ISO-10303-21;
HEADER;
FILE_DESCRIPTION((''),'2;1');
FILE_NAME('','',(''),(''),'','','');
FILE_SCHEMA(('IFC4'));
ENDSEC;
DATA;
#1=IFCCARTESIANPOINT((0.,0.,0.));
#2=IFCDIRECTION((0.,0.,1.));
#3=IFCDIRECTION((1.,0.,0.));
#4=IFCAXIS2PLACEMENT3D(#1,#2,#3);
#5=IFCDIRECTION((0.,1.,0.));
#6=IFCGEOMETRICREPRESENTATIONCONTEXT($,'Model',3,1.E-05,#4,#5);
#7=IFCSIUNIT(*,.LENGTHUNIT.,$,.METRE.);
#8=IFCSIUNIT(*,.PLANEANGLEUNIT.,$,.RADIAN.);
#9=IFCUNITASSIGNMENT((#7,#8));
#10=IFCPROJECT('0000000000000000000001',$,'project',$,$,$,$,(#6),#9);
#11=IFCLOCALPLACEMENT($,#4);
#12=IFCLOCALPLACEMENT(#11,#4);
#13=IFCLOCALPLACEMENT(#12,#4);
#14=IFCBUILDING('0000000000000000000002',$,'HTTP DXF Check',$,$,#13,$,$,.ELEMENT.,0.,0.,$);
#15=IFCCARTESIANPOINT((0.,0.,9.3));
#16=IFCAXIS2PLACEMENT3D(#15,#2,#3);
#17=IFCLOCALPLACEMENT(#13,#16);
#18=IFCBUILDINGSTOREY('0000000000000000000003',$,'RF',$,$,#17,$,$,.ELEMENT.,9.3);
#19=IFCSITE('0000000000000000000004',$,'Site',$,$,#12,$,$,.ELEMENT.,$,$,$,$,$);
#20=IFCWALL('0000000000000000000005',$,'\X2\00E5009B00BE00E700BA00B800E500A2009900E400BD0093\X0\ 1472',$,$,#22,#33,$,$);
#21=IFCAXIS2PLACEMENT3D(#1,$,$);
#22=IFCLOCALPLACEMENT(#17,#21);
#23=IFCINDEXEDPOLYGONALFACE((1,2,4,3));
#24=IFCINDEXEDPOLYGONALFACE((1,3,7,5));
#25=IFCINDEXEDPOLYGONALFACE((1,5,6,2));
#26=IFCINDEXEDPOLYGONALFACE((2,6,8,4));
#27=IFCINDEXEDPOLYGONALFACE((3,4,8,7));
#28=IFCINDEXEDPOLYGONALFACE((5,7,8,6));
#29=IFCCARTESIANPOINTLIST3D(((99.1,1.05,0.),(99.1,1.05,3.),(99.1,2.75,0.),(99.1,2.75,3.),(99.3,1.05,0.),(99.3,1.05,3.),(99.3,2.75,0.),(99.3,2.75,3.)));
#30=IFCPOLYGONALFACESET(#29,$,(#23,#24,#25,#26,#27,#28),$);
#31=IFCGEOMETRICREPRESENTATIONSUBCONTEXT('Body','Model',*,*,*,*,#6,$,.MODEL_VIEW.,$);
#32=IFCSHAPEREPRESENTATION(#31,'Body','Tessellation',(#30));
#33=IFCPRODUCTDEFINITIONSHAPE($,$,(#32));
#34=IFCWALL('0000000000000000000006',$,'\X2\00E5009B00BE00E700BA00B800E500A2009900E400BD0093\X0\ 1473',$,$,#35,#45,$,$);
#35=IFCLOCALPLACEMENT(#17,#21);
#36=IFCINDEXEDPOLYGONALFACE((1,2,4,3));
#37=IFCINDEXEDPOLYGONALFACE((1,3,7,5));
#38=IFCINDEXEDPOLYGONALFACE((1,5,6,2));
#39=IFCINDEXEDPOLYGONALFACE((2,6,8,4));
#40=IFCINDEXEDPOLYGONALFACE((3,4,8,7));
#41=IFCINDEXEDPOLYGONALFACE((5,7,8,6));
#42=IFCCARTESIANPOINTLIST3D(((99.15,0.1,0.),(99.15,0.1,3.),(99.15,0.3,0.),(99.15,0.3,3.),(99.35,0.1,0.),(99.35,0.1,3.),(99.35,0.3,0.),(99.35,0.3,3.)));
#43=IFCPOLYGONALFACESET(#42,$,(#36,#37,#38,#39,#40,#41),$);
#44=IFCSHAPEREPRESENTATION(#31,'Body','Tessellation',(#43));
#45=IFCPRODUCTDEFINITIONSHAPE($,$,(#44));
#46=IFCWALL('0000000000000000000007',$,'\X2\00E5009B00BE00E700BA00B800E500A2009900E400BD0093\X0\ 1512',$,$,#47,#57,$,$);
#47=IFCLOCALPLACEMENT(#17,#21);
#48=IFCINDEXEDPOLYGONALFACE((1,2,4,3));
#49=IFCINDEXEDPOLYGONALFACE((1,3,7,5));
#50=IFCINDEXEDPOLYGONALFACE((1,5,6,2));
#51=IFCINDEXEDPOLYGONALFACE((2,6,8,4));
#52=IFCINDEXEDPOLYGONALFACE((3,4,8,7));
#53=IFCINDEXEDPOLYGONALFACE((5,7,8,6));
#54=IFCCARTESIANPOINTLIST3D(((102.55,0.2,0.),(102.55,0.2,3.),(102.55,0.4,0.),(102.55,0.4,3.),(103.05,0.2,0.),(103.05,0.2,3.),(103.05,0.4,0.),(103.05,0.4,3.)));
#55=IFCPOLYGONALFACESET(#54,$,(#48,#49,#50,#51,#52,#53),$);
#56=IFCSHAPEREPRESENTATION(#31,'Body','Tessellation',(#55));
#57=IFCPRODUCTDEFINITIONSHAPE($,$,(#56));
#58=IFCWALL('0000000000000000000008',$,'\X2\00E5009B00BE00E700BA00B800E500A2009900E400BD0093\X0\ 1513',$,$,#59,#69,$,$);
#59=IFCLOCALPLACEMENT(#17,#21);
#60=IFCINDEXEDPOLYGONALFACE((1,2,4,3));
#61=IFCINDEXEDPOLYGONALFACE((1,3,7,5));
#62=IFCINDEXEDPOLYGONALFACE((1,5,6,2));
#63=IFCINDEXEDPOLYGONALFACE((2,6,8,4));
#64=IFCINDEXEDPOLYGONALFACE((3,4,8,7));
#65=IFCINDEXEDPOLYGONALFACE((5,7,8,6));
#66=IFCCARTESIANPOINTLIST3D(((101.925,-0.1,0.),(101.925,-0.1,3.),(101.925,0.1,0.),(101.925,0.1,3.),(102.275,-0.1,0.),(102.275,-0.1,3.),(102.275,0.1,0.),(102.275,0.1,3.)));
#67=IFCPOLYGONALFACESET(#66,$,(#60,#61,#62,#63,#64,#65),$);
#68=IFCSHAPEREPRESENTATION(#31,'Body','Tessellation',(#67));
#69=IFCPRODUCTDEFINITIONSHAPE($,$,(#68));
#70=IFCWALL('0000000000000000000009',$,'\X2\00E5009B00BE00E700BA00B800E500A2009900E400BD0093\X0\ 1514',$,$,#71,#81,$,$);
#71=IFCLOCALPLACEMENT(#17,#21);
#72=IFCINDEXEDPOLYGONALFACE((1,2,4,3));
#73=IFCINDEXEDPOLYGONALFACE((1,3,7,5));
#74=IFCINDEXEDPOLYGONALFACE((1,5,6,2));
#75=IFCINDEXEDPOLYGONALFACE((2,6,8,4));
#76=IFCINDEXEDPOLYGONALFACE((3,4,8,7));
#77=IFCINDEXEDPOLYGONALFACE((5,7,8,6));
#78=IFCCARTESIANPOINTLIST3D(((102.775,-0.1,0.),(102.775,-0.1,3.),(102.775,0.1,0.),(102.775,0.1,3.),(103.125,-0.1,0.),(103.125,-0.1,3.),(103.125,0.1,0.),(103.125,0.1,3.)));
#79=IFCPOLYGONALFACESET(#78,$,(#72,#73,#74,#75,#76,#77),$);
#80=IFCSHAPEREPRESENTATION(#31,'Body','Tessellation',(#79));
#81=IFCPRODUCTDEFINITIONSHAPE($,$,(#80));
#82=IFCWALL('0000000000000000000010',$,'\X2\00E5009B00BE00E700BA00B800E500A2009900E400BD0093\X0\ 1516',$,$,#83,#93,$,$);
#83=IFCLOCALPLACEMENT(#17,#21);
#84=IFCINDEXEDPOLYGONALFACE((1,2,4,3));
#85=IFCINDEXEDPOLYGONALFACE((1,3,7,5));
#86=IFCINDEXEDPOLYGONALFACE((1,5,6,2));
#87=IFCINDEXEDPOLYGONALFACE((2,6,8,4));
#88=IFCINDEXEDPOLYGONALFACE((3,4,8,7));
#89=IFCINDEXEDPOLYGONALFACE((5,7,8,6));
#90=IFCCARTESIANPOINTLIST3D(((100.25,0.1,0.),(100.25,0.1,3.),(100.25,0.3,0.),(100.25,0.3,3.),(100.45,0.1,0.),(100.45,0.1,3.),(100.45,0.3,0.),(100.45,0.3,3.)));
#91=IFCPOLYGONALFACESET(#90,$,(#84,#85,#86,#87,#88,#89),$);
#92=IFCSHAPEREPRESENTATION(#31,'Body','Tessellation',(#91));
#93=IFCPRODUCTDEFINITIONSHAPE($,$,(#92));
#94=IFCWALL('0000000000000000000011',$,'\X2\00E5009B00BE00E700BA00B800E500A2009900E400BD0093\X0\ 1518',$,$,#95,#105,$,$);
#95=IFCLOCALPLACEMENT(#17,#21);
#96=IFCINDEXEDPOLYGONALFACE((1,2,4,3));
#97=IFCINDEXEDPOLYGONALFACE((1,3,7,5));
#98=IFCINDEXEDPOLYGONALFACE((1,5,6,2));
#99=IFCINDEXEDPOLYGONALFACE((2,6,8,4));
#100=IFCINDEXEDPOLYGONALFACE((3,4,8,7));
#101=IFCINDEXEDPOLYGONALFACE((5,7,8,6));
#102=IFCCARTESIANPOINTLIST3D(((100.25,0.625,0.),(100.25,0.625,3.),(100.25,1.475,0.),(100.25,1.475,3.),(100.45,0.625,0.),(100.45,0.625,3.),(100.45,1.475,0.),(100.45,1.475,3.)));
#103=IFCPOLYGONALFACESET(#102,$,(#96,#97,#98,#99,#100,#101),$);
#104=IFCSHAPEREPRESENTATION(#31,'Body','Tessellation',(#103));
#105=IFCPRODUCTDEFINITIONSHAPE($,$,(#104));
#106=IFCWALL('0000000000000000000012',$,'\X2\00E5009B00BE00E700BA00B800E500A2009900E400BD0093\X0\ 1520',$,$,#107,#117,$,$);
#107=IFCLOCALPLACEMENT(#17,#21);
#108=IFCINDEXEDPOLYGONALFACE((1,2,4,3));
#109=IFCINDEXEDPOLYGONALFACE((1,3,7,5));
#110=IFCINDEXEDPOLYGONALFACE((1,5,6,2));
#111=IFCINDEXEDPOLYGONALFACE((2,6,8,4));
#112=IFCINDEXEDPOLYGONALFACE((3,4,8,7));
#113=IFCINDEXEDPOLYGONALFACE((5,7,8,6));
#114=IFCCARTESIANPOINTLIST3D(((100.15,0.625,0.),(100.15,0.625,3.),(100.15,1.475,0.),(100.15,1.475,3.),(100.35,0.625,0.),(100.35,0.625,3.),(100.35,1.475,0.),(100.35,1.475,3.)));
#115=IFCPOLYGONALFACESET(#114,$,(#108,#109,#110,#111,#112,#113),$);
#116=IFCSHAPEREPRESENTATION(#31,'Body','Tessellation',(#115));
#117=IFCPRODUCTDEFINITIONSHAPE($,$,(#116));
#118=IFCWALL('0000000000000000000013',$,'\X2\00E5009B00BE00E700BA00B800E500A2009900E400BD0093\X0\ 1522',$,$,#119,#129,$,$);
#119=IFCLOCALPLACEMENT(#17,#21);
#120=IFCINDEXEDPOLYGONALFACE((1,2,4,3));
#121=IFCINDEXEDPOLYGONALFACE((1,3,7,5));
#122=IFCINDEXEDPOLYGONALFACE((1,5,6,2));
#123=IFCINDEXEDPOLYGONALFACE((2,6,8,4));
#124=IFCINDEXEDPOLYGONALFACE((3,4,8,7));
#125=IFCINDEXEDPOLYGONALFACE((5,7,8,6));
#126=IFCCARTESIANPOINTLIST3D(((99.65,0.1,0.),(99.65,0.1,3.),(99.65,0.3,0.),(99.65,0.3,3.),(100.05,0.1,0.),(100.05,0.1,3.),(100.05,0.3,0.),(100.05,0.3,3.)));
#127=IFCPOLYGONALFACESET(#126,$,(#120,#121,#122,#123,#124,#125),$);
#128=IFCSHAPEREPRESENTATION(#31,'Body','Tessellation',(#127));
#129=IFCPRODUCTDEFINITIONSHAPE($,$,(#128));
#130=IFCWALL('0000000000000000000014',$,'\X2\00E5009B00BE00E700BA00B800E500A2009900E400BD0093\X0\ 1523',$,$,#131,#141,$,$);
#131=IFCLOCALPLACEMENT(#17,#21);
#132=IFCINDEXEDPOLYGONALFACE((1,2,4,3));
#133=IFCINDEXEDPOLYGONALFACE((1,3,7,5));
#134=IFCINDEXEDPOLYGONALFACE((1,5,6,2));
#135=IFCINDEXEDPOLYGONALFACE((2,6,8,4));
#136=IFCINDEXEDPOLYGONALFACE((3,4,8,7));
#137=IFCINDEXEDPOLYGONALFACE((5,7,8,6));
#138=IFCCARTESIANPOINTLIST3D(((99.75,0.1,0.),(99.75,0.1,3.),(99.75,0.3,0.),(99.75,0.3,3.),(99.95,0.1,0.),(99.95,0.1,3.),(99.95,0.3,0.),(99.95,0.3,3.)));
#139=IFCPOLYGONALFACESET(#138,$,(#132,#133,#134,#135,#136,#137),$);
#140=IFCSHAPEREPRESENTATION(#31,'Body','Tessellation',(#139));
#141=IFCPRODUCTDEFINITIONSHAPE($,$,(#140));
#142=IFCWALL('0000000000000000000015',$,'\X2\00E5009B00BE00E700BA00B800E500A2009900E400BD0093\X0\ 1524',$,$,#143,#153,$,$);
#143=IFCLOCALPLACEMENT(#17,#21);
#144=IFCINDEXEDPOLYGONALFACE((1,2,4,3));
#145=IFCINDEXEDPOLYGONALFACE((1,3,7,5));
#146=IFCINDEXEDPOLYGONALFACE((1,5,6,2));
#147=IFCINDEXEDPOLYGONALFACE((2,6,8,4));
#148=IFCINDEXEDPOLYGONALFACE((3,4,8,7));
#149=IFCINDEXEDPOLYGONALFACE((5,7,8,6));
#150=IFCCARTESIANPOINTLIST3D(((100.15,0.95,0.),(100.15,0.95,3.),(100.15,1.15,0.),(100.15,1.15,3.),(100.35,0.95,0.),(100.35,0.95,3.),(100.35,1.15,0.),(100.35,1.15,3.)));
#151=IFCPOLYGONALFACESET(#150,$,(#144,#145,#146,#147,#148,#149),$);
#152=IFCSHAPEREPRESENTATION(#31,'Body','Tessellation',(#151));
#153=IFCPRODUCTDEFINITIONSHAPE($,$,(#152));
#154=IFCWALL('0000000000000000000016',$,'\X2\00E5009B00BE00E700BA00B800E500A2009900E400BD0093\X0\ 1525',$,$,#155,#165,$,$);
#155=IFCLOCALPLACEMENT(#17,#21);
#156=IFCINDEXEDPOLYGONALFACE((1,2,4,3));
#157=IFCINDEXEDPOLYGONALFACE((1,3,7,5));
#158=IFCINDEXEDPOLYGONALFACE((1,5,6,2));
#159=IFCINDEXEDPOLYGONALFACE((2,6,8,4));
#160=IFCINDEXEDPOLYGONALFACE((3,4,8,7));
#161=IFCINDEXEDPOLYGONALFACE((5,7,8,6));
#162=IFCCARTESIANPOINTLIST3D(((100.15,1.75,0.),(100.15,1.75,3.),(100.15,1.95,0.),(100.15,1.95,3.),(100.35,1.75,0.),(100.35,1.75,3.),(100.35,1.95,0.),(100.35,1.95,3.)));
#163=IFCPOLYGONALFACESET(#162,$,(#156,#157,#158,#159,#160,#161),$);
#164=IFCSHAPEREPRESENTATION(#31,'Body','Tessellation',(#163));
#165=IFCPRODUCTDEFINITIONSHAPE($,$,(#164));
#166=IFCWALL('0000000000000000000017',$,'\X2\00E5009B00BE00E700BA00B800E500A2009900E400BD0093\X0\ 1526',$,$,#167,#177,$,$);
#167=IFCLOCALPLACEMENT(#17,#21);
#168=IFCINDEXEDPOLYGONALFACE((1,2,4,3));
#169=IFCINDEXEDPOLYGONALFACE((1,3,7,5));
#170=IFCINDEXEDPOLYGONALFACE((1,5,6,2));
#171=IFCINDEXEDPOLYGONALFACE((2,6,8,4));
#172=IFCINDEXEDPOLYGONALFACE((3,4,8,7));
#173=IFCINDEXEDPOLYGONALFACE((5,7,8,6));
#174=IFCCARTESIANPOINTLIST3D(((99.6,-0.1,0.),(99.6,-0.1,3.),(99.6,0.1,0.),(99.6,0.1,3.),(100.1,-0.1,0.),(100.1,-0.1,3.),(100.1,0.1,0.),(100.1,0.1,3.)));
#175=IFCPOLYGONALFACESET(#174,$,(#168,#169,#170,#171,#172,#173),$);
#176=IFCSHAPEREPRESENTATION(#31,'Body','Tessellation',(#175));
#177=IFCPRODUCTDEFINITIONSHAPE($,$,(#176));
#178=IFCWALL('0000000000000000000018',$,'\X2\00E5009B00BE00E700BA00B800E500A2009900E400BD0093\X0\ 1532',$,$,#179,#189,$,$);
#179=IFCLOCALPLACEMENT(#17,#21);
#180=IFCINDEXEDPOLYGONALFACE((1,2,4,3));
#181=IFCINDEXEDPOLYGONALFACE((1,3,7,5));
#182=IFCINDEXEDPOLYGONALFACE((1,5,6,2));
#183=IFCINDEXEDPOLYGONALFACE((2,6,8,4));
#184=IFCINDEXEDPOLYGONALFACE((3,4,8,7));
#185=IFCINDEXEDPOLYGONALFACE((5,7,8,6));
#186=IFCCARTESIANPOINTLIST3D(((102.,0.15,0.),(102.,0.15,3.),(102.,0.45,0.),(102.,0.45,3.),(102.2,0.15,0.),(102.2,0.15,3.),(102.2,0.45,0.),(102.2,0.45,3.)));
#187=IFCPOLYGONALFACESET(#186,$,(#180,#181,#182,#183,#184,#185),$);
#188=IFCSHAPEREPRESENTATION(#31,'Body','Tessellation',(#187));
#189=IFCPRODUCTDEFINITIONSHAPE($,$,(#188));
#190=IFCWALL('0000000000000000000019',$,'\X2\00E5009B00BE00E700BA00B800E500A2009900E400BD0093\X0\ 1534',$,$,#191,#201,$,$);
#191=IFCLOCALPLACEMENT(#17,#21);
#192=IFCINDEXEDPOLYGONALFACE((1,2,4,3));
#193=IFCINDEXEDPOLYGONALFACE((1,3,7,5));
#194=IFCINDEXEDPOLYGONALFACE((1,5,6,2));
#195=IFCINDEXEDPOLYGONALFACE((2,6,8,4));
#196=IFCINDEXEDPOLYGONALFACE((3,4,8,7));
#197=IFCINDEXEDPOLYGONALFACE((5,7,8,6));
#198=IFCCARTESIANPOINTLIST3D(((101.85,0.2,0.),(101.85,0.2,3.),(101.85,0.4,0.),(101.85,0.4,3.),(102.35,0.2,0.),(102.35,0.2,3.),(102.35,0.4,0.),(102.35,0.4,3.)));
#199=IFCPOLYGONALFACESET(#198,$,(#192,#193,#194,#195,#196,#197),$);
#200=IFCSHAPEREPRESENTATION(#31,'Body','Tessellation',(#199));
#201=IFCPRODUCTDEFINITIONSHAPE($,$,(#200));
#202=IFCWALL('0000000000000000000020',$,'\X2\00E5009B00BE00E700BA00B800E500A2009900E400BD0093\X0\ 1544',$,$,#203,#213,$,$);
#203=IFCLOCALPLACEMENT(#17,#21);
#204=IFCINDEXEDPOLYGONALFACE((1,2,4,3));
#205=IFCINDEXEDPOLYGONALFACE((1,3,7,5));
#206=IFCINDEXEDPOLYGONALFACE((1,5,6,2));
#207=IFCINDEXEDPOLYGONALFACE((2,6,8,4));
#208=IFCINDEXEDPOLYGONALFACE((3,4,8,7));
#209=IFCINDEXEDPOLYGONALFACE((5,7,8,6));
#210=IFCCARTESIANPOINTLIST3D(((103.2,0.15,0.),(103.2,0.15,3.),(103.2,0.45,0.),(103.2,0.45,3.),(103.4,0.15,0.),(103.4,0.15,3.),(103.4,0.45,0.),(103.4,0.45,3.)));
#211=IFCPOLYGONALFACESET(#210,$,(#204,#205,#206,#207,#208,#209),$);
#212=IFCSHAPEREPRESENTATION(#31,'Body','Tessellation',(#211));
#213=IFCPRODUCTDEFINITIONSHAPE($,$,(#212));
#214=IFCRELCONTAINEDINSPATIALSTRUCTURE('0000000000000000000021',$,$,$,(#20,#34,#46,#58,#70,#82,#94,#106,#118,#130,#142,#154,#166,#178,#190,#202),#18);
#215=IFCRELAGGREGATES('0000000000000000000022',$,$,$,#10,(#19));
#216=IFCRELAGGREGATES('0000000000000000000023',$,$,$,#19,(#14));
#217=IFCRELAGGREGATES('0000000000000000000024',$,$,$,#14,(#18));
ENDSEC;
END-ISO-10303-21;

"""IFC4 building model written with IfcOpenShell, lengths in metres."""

from ifc_helpers import new_model, si_unit, direction, frame, frame_2d, origin_with_axes, place, context, subcontext, project, spatial, rectangle, extrude, element, save


model = new_model("IFC4")

# Units and contexts
model_context = context("Model", 3, precision=1e-05, world=origin_with_axes(), true_north=direction((0.0, 1.0, 0.0)))
body_context = subcontext(model_context, "Body", "Model", "MODEL_VIEW")
ifc_project = project(units=[si_unit("LENGTHUNIT", "METRE"), si_unit("PLANEANGLEUNIT", "RADIAN")], contexts=[model_context])

# Site, building, storey
placement = place(None, origin_with_axes())
site_placement = place(placement, origin_with_axes())
site = spatial("IfcSite", under=ifc_project, at=site_placement, Name="Site", CompositionType="ELEMENT")
building_placement = place(site_placement, origin_with_axes())
building = spatial("IfcBuilding", under=site, at=building_placement, Name="HTTP DXF Check", CompositionType="ELEMENT", ElevationOfRefHeight=0.0, ElevationOfTerrain=0.0)
storey_placement = place(building_placement, frame((0.0, 0.0, 9.3), z_axis=(0.0, 0.0, 1.0), x_axis=(1.0, 0.0, 0.0)))
storey = spatial("IfcBuildingStorey", under=building, at=storey_placement, Name="RF", CompositionType="ELEMENT", Elevation=9.3)

# Walls
wall_1_placement = place(storey_placement, frame((99.2, 1.9, 0.0), z_axis=(0.0, 0.0, 1.0), x_axis=(0.0, -1.0, 0.0)))
element("IfcWall", 1, at=wall_1_placement, inside=storey, Name="å\u009b¾çº¸å¢\u0099ä½\u0093 1472", context=body_context, shape_type="SweptSolid", body=[
    extrude(rectangle(XDim=1.7, YDim=0.2, at=frame_2d((0.0, 0.0), x_axis=(1.0, 0.0, 0.0))), frame((0.0, 0.0, 0.0), z_axis=(0.0, 0.0, 1.0)), (0.0, 0.0, 1.0), 3.0),
])
wall_2_placement = place(storey_placement, frame((99.25, 0.2, 0.0), z_axis=(0.0, 0.0, 1.0), x_axis=(0.0, -1.0, 0.0)))
element("IfcWall", 2, at=wall_2_placement, inside=storey, Name="å\u009b¾çº¸å¢\u0099ä½\u0093 1473", context=body_context, shape_type="SweptSolid", body=[
    extrude(rectangle(XDim=0.2, YDim=0.2, at=frame_2d((0.0, 0.0), x_axis=(1.0, 0.0, 0.0))), frame((0.0, 0.0, 0.0), z_axis=(0.0, 0.0, 1.0)), (0.0, 0.0, 1.0), 3.0),
])
wall_3_placement = place(storey_placement, frame((102.8, 0.3, 0.0), z_axis=(0.0, 0.0, 1.0), x_axis=(1.0, 0.0, 0.0)))
element("IfcWall", 3, at=wall_3_placement, inside=storey, Name="å\u009b¾çº¸å¢\u0099ä½\u0093 1512", context=body_context, shape_type="SweptSolid", body=[
    extrude(rectangle(XDim=0.5, YDim=0.2, at=frame_2d((0.0, 0.0), x_axis=(1.0, 0.0, 0.0))), frame((0.0, 0.0, 0.0), z_axis=(0.0, 0.0, 1.0)), (0.0, 0.0, 1.0), 3.0),
])
for number, where, z_axis, x_axis, name in (
    (4, (102.1, 0.0, 0.0), (0.0, 0.0, 1.0), (1.0, 0.0, 0.0), "å\u009b¾çº¸å¢\u0099ä½\u0093 1513"),
    (5, (102.95, 0.0, 0.0), (0.0, 0.0, 1.0), (1.0, 0.0, 0.0), "å\u009b¾çº¸å¢\u0099ä½\u0093 1514"),
):
    element("IfcWall", number, at=place(storey_placement, frame(where, z_axis=z_axis, x_axis=x_axis)), inside=storey, Name=name, context=body_context, shape_type="SweptSolid", body=[
        extrude(rectangle(XDim=0.35, YDim=0.2, at=frame_2d((0.0, 0.0), x_axis=(1.0, 0.0, 0.0))), frame((0.0, 0.0, 0.0), z_axis=(0.0, 0.0, 1.0)), (0.0, 0.0, 1.0), 3.0),
    ])
wall_4_placement = place(storey_placement, frame((100.35, 0.2, 0.0), z_axis=(0.0, 0.0, 1.0), x_axis=(0.0, -1.0, 0.0)))
element("IfcWall", 6, at=wall_4_placement, inside=storey, Name="å\u009b¾çº¸å¢\u0099ä½\u0093 1516", context=body_context, shape_type="SweptSolid", body=[
    extrude(rectangle(XDim=0.2, YDim=0.2, at=frame_2d((0.0, 0.0), x_axis=(1.0, 0.0, 0.0))), frame((0.0, 0.0, 0.0), z_axis=(0.0, 0.0, 1.0)), (0.0, 0.0, 1.0), 3.0),
])
for number, where, z_axis, x_axis, name in (
    (7, (100.35, 1.05, 0.0), (0.0, 0.0, 1.0), (0.0, -1.0, 0.0), "å\u009b¾çº¸å¢\u0099ä½\u0093 1518"),
    (8, (100.25, 1.05, 0.0), (0.0, 0.0, 1.0), (0.0, -1.0, 0.0), "å\u009b¾çº¸å¢\u0099ä½\u0093 1520"),
):
    element("IfcWall", number, at=place(storey_placement, frame(where, z_axis=z_axis, x_axis=x_axis)), inside=storey, Name=name, context=body_context, shape_type="SweptSolid", body=[
        extrude(rectangle(XDim=0.85, YDim=0.2, at=frame_2d((0.0, 0.0), x_axis=(1.0, 0.0, 0.0))), frame((0.0, 0.0, 0.0), z_axis=(0.0, 0.0, 1.0)), (0.0, 0.0, 1.0), 3.0),
    ])
wall_5_placement = place(storey_placement, frame((99.85, 0.2, 0.0), z_axis=(0.0, 0.0, 1.0), x_axis=(1.0, 0.0, 0.0)))
element("IfcWall", 9, at=wall_5_placement, inside=storey, Name="å\u009b¾çº¸å¢\u0099ä½\u0093 1522", context=body_context, shape_type="SweptSolid", body=[
    extrude(rectangle(XDim=0.4, YDim=0.2, at=frame_2d((0.0, 0.0), x_axis=(1.0, 0.0, 0.0))), frame((0.0, 0.0, 0.0), z_axis=(0.0, 0.0, 1.0)), (0.0, 0.0, 1.0), 3.0),
])
for number, where, z_axis, x_axis, name in (
    (10, (99.85, 0.2, 0.0), (0.0, 0.0, 1.0), (0.0, -1.0, 0.0), "å\u009b¾çº¸å¢\u0099ä½\u0093 1523"),
    (11, (100.25, 1.05, 0.0), (0.0, 0.0, 1.0), (1.0, 0.0, 0.0), "å\u009b¾çº¸å¢\u0099ä½\u0093 1524"),
    (12, (100.25, 1.85, 0.0), (0.0, 0.0, 1.0), (1.0, 0.0, 0.0), "å\u009b¾çº¸å¢\u0099ä½\u0093 1525"),
):
    element("IfcWall", number, at=place(storey_placement, frame(where, z_axis=z_axis, x_axis=x_axis)), inside=storey, Name=name, context=body_context, shape_type="SweptSolid", body=[
        extrude(rectangle(XDim=0.2, YDim=0.2, at=frame_2d((0.0, 0.0), x_axis=(1.0, 0.0, 0.0))), frame((0.0, 0.0, 0.0), z_axis=(0.0, 0.0, 1.0)), (0.0, 0.0, 1.0), 3.0),
    ])
wall_6_placement = place(storey_placement, frame((99.85, 0.0, 0.0), z_axis=(0.0, 0.0, 1.0), x_axis=(1.0, 0.0, 0.0)))
element("IfcWall", 13, at=wall_6_placement, inside=storey, Name="å\u009b¾çº¸å¢\u0099ä½\u0093 1526", context=body_context, shape_type="SweptSolid", body=[
    extrude(rectangle(XDim=0.5, YDim=0.2, at=frame_2d((0.0, 0.0), x_axis=(1.0, 0.0, 0.0))), frame((0.0, 0.0, 0.0), z_axis=(0.0, 0.0, 1.0)), (0.0, 0.0, 1.0), 3.0),
])
wall_7_placement = place(storey_placement, frame((102.1, 0.3, 0.0), z_axis=(0.0, 0.0, 1.0), x_axis=(0.0, -1.0, 0.0)))
element("IfcWall", 14, at=wall_7_placement, inside=storey, Name="å\u009b¾çº¸å¢\u0099ä½\u0093 1532", context=body_context, shape_type="SweptSolid", body=[
    extrude(rectangle(XDim=0.3, YDim=0.2, at=frame_2d((0.0, 0.0), x_axis=(1.0, 0.0, 0.0))), frame((0.0, 0.0, 0.0), z_axis=(0.0, 0.0, 1.0)), (0.0, 0.0, 1.0), 3.0),
])
wall_8_placement = place(storey_placement, frame((102.1, 0.3, 0.0), z_axis=(0.0, 0.0, 1.0), x_axis=(1.0, 0.0, 0.0)))
element("IfcWall", 15, at=wall_8_placement, inside=storey, Name="å\u009b¾çº¸å¢\u0099ä½\u0093 1534", context=body_context, shape_type="SweptSolid", body=[
    extrude(rectangle(XDim=0.5, YDim=0.2, at=frame_2d((0.0, 0.0), x_axis=(1.0, 0.0, 0.0))), frame((0.0, 0.0, 0.0), z_axis=(0.0, 0.0, 1.0)), (0.0, 0.0, 1.0), 3.0),
])
wall_9_placement = place(storey_placement, frame((103.3, 0.3, 0.0), z_axis=(0.0, 0.0, 1.0), x_axis=(0.0, -1.0, 0.0)))
element("IfcWall", 16, at=wall_9_placement, inside=storey, Name="å\u009b¾çº¸å¢\u0099ä½\u0093 1544", context=body_context, shape_type="SweptSolid", body=[
    extrude(rectangle(XDim=0.3, YDim=0.2, at=frame_2d((0.0, 0.0), x_axis=(1.0, 0.0, 0.0))), frame((0.0, 0.0, 0.0), z_axis=(0.0, 0.0, 1.0)), (0.0, 0.0, 1.0), 3.0),
])

save(model, "model.ifc")
